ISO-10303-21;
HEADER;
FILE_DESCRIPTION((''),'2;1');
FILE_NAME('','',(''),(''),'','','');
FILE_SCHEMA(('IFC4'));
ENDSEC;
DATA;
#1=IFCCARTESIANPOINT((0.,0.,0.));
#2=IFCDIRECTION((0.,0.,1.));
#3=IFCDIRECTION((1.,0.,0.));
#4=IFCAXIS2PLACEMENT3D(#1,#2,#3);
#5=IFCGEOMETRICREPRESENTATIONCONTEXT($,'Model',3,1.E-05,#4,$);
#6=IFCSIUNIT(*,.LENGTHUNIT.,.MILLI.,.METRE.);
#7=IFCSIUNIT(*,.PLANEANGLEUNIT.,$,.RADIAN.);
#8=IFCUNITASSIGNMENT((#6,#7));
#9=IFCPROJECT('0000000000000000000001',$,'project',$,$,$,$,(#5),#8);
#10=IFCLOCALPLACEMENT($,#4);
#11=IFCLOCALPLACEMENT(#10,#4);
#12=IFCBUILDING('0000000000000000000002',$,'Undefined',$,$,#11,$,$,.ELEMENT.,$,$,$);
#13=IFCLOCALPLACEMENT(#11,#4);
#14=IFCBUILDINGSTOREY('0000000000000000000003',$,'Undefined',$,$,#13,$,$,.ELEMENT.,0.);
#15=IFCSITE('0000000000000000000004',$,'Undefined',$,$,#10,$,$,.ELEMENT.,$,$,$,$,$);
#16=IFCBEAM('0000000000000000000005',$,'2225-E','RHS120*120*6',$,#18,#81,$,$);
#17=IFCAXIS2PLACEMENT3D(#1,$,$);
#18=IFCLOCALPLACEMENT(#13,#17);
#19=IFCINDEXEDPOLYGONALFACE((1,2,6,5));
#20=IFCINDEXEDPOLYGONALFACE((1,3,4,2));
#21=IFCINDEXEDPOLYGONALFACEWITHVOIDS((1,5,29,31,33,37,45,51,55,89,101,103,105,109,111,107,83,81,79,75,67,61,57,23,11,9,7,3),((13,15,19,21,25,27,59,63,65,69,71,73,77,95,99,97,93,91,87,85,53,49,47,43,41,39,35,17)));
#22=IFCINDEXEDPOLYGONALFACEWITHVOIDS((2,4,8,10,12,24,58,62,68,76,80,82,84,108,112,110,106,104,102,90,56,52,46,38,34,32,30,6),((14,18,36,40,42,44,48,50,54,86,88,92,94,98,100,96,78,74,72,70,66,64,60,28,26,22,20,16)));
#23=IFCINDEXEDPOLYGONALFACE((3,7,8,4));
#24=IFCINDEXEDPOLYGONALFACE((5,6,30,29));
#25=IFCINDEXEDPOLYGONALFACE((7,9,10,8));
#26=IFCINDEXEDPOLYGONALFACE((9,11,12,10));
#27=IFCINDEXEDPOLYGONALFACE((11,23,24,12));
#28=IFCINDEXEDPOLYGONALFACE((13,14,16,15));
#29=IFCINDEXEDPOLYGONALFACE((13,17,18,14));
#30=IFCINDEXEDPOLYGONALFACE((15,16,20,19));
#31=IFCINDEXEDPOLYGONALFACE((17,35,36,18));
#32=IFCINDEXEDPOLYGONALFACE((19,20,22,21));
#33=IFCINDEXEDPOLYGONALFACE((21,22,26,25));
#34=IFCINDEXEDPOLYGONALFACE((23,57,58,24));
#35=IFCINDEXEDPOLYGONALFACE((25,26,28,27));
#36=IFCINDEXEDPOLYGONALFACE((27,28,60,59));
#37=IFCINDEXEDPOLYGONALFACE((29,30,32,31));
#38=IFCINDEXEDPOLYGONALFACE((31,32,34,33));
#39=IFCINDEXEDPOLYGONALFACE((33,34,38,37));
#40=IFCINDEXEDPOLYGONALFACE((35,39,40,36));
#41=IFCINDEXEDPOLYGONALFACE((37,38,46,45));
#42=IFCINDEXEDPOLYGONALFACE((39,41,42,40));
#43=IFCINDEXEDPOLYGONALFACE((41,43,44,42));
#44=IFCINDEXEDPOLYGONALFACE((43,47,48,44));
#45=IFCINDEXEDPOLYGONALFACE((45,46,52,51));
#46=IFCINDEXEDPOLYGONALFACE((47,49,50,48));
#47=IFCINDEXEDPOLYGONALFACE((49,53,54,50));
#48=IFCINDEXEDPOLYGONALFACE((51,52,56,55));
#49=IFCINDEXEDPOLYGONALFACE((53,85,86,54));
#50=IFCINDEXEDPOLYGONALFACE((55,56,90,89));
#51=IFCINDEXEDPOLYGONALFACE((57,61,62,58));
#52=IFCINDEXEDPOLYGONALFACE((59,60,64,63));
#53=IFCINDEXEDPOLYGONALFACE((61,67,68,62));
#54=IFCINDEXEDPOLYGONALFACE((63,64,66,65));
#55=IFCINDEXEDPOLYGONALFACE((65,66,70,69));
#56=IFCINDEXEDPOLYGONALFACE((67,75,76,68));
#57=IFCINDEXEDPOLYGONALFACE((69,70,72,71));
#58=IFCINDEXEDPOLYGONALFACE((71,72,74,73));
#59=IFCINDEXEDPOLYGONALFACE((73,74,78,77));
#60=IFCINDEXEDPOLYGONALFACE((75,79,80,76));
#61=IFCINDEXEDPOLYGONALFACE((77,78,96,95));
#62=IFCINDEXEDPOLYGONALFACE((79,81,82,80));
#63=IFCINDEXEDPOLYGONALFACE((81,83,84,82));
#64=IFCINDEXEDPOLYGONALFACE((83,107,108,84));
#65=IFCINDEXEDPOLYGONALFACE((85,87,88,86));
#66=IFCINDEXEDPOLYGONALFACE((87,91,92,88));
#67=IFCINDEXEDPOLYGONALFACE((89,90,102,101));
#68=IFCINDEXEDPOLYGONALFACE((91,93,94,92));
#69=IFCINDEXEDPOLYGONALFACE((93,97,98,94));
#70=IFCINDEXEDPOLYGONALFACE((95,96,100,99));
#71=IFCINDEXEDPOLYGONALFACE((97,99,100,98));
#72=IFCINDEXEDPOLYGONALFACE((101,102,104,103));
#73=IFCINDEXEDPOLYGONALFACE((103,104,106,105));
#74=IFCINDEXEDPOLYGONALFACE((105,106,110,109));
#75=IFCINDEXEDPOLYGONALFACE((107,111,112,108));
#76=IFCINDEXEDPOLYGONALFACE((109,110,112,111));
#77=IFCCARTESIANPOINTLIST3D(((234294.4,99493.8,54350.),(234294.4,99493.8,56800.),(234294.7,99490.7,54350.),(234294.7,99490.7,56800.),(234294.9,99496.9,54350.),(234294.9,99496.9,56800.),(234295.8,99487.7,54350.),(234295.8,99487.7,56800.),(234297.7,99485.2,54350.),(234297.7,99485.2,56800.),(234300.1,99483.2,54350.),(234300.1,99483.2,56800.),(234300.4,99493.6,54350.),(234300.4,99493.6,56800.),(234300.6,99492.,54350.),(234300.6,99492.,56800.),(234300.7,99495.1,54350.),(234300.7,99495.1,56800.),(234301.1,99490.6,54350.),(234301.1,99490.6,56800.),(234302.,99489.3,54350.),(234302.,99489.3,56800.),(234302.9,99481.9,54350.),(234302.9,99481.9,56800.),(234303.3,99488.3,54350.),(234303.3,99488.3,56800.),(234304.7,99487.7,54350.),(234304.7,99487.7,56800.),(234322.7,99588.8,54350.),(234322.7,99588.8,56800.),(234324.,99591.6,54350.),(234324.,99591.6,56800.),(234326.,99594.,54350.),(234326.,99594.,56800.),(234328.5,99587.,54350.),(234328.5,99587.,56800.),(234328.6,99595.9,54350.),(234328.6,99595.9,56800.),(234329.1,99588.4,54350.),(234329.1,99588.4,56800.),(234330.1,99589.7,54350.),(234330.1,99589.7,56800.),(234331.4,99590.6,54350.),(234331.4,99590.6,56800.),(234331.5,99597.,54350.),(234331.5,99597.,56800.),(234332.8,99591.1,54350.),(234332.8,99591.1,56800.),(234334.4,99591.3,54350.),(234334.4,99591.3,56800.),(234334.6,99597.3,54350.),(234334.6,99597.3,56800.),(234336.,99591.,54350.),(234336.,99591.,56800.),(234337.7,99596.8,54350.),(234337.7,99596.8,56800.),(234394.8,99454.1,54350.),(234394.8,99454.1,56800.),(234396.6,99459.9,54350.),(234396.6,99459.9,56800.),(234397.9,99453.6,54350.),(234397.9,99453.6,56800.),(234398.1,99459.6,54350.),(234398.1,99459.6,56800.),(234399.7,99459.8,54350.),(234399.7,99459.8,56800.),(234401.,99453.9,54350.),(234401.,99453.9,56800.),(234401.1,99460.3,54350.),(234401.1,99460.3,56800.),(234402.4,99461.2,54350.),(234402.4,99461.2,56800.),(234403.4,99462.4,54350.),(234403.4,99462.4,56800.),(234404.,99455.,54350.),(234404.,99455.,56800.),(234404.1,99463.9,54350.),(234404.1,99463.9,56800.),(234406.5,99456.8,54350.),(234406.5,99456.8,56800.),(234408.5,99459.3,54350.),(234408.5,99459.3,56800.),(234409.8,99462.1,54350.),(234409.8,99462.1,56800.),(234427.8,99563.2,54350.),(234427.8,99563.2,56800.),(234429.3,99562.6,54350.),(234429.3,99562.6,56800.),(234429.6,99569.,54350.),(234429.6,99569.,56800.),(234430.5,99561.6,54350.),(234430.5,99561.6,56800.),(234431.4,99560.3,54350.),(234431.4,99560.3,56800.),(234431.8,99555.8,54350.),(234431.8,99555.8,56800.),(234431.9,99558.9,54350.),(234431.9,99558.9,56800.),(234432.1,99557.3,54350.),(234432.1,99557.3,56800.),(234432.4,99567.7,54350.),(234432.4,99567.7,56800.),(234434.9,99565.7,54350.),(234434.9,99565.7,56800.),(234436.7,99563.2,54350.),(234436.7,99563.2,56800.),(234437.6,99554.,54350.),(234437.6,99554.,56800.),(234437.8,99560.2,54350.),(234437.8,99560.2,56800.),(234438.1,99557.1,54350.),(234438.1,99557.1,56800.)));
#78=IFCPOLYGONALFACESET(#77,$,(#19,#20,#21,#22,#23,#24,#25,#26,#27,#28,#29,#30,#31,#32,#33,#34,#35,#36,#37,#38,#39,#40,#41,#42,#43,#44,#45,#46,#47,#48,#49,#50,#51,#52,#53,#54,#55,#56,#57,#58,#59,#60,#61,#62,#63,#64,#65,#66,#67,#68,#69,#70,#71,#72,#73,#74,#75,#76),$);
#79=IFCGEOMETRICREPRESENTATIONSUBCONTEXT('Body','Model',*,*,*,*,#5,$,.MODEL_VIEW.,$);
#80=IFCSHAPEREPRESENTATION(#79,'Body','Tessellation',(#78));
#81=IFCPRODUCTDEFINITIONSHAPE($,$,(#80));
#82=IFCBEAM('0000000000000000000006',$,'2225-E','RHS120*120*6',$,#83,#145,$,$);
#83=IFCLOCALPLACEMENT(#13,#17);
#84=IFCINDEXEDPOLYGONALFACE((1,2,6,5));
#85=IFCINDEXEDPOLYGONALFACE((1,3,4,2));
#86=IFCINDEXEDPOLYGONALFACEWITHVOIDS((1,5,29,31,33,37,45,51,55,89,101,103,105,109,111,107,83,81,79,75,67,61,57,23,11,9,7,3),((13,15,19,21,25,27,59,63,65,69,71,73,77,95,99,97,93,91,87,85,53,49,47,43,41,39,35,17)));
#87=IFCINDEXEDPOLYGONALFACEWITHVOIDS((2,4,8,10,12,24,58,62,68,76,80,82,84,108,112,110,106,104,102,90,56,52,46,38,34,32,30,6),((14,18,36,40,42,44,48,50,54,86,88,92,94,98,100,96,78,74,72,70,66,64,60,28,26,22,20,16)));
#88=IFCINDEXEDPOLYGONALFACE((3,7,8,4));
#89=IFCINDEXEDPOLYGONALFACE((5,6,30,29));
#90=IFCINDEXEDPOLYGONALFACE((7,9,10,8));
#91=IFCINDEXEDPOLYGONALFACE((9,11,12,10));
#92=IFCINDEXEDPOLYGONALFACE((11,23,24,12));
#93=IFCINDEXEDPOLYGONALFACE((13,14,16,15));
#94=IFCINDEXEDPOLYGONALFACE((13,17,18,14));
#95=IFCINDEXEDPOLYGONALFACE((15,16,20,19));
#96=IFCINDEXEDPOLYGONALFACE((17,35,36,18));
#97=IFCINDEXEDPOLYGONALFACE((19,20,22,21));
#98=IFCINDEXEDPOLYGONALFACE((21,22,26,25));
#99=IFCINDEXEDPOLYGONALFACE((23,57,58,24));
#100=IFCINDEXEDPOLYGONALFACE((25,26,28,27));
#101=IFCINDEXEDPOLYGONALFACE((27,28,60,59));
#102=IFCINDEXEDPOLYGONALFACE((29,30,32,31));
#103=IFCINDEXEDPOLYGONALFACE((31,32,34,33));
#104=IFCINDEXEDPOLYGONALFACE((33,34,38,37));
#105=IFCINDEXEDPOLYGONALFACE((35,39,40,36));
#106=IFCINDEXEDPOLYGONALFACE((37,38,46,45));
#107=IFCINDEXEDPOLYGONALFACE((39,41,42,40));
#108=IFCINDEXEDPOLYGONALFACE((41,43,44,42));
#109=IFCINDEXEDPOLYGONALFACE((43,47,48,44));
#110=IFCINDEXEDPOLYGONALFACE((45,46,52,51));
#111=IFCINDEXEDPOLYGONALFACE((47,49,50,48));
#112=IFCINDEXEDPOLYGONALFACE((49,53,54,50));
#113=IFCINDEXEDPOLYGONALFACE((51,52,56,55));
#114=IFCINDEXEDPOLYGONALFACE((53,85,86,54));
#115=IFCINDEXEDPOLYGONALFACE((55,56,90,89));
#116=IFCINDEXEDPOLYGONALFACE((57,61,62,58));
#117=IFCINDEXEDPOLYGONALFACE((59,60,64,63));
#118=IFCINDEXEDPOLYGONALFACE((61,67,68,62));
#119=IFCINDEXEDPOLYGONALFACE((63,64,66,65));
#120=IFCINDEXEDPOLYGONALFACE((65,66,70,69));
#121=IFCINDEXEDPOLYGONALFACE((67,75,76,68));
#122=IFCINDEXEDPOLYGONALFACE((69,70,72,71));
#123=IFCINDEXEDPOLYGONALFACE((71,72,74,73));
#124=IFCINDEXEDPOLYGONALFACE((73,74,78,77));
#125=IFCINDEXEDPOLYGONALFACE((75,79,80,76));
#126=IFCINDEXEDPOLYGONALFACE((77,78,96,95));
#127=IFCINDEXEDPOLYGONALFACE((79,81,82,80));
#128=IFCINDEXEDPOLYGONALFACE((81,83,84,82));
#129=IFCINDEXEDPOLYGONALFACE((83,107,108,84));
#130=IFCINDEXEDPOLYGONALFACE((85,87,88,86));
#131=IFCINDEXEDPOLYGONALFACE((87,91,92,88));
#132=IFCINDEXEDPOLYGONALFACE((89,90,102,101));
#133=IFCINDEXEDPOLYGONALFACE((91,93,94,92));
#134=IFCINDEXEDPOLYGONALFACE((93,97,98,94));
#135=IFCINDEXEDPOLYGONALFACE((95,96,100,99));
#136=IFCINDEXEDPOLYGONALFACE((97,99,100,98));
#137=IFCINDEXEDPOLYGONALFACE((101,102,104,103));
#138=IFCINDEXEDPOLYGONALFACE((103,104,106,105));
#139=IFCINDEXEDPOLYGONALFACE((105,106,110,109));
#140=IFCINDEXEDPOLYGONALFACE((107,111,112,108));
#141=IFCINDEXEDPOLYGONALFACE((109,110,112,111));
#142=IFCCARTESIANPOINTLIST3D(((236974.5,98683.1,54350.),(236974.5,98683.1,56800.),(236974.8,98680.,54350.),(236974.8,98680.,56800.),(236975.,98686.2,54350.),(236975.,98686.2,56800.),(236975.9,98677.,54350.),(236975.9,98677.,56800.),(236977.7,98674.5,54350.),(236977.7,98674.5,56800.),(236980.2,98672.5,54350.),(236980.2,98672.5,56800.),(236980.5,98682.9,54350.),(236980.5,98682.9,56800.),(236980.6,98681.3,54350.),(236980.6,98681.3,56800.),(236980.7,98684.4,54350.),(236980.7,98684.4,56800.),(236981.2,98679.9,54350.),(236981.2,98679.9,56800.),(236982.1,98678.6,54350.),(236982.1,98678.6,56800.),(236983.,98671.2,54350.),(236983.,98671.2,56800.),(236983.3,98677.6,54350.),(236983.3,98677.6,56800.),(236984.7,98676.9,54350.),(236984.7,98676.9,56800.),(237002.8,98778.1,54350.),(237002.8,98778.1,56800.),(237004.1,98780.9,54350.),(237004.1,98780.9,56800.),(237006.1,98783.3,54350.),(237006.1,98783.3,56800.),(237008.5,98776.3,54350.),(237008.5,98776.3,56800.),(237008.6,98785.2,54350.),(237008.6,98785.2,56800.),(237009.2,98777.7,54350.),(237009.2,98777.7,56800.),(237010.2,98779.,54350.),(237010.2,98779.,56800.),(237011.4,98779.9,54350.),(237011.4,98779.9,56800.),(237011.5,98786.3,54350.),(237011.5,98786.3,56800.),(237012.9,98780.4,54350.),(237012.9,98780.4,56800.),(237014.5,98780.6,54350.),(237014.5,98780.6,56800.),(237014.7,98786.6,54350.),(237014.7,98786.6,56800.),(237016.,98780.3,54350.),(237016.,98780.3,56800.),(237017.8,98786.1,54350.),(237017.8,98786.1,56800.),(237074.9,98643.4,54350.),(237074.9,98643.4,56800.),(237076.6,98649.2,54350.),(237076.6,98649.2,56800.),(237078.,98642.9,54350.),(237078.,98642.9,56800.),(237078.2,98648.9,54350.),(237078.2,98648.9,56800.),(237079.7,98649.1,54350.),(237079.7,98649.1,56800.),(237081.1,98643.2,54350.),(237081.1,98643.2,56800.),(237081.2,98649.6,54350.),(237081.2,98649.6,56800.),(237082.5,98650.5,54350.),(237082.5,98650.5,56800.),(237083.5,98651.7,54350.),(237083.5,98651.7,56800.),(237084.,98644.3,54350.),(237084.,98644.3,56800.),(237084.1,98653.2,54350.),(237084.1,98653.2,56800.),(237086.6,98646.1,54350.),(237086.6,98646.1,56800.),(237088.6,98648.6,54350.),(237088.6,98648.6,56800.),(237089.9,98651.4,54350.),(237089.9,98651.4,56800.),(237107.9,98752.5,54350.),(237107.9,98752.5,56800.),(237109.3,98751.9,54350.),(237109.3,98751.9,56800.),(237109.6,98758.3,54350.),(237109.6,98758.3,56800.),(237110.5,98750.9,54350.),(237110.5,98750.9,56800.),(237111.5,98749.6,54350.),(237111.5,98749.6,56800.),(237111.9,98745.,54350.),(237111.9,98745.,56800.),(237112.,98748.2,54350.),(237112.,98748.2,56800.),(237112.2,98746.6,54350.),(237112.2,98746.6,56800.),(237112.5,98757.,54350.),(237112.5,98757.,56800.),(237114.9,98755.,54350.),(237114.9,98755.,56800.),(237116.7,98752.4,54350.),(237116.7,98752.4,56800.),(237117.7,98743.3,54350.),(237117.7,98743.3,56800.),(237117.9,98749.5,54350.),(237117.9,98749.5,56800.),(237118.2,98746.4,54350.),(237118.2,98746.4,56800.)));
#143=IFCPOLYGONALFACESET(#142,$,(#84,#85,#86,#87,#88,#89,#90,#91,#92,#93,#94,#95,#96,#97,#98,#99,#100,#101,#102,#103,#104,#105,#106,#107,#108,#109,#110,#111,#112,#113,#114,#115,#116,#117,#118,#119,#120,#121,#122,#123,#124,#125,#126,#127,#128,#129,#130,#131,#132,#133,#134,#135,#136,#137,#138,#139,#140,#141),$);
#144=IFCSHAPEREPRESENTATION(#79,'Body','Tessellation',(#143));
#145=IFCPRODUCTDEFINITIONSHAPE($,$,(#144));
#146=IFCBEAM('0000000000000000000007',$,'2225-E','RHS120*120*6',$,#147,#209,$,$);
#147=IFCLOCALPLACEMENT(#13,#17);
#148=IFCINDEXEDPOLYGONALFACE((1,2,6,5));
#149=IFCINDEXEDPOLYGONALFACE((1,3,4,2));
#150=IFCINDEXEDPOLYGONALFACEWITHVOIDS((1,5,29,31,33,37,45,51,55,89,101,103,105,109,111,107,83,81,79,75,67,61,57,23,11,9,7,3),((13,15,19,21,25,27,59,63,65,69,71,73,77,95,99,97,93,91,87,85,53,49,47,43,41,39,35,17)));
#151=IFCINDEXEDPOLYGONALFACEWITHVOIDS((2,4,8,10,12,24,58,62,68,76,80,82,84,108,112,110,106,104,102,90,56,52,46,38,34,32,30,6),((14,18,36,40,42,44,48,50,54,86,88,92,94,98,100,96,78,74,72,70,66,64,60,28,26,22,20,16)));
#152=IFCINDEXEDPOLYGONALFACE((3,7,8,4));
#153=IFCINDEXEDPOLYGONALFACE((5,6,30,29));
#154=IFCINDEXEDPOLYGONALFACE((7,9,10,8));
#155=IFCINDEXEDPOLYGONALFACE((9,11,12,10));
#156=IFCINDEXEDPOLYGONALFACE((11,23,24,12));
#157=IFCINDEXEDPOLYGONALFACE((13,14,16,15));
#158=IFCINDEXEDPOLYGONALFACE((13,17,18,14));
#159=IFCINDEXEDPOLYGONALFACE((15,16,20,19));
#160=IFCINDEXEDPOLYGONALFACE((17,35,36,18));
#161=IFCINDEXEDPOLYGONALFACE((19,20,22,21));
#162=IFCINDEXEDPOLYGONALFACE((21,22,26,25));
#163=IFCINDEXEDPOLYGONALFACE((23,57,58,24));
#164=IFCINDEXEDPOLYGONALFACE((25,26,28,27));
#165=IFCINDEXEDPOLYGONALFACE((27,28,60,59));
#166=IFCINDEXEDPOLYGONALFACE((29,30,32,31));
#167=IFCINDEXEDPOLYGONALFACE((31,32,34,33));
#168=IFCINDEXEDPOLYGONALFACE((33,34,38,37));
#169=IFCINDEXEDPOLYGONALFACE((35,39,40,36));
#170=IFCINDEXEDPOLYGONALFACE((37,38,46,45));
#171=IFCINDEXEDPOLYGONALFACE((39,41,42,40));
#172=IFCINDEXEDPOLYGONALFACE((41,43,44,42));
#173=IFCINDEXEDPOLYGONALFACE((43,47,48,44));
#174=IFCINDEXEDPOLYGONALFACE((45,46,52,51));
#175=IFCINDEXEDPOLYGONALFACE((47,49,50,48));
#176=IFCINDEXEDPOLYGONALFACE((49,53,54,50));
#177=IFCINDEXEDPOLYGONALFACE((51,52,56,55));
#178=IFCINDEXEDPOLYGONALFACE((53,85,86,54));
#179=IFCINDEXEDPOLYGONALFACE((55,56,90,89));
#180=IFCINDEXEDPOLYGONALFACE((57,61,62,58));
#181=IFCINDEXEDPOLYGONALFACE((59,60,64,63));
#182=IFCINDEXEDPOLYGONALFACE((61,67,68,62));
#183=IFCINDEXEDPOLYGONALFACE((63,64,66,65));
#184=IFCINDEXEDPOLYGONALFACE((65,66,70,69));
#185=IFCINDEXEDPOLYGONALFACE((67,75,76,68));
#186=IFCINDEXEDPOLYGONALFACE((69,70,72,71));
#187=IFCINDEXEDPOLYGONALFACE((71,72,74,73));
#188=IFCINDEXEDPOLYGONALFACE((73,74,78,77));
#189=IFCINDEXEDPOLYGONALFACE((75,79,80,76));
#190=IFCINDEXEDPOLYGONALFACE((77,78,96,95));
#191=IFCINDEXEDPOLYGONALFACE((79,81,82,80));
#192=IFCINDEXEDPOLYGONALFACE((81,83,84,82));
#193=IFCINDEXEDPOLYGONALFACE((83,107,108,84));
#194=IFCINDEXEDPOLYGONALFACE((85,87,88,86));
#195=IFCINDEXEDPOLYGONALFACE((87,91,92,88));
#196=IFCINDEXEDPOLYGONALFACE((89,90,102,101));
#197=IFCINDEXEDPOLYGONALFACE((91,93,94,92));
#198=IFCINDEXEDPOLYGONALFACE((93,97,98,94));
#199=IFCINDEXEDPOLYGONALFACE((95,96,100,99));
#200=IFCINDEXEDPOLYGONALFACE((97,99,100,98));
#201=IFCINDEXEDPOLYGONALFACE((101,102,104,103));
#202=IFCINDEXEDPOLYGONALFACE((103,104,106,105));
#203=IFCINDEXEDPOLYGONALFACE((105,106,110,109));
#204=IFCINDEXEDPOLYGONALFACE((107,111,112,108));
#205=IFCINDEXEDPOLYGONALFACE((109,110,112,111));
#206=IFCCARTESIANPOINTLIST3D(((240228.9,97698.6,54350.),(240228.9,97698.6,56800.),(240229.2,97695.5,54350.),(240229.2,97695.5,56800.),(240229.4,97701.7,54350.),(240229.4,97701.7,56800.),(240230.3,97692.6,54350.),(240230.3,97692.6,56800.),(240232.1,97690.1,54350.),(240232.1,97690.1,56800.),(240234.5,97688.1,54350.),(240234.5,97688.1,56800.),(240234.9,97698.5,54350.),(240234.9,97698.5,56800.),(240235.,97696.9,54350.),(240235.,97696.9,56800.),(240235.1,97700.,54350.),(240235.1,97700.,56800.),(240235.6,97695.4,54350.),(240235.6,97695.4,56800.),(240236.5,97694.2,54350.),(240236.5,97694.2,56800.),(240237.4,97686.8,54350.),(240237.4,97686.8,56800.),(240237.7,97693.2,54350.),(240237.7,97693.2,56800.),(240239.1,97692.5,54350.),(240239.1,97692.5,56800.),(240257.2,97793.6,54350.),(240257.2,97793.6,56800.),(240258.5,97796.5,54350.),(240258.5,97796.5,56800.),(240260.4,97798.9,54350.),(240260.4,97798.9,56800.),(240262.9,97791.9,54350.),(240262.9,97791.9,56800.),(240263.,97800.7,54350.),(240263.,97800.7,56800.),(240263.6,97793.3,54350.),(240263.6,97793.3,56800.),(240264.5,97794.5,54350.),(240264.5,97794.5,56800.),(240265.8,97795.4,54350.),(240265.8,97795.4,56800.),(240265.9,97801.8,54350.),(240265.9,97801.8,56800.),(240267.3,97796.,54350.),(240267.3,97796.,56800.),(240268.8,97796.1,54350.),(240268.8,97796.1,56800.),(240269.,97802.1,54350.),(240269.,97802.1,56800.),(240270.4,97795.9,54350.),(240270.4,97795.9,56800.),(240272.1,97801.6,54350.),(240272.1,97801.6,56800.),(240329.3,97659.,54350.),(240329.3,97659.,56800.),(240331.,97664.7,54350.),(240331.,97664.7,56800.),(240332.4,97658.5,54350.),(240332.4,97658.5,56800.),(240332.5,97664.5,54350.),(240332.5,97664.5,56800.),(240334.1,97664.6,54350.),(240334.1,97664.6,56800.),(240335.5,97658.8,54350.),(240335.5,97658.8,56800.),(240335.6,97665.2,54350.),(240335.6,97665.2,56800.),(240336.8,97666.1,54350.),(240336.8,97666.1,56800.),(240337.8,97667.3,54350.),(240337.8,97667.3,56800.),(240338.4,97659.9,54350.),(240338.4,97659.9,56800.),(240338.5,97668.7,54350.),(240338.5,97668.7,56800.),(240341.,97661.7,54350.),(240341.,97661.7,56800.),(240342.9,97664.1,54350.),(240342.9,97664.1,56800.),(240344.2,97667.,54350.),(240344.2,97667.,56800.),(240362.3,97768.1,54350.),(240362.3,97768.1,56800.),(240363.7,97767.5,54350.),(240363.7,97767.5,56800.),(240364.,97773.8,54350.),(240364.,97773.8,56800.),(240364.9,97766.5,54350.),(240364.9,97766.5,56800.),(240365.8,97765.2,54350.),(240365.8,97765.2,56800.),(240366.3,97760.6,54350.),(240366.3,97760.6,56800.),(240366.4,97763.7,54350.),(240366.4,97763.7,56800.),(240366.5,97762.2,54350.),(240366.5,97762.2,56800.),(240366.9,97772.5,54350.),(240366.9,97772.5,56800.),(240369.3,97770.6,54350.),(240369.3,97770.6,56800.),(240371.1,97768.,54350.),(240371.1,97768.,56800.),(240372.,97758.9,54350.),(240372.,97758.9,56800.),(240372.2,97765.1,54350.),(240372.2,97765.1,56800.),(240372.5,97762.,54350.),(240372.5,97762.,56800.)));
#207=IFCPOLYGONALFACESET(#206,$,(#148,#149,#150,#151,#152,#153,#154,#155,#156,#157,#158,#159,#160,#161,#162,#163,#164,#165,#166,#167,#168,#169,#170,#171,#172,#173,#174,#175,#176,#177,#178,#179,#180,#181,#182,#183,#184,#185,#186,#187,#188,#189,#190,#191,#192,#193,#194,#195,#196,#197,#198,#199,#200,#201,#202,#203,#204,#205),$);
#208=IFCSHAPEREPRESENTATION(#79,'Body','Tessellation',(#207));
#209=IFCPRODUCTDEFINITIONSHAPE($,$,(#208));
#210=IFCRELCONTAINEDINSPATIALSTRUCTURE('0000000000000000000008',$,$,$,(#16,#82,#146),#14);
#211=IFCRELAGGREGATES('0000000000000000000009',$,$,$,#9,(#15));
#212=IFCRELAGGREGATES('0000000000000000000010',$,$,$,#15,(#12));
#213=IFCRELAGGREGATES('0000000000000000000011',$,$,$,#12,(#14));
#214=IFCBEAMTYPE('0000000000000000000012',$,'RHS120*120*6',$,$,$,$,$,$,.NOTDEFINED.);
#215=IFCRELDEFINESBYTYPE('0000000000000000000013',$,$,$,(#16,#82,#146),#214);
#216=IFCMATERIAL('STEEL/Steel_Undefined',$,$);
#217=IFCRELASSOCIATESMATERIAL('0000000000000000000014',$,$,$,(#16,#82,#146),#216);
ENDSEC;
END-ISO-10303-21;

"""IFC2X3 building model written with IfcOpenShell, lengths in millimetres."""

from ifc_helpers import new_model, si_unit, frame, origin_with_axes, origin_2d_with_axis, place, context, subcontext, project, spatial, hollow_rectangle, extrude, material, type_object, element, save


model = new_model("IFC2X3")

# Units and contexts
model_context = context("Model", 3, precision=1e-05, world=origin_with_axes())
body_context = subcontext(model_context, "Body", "Model", "MODEL_VIEW")
ifc_project = project(units=[si_unit("LENGTHUNIT", "METRE", prefix="MILLI"), si_unit("PLANEANGLEUNIT", "RADIAN")], contexts=[model_context])

# Site, building, storey
site_placement = place(None, origin_with_axes())
site = spatial("IfcSite", under=ifc_project, at=site_placement, Name="Undefined", CompositionType="ELEMENT")
building_placement = place(site_placement, origin_with_axes())
building = spatial("IfcBuilding", under=site, at=building_placement, Name="Undefined", CompositionType="ELEMENT")
storey_placement = place(building_placement, origin_with_axes())
storey = spatial("IfcBuildingStorey", under=building, at=storey_placement, Name="Undefined", CompositionType="ELEMENT", Elevation=0.0)

# Shared definitions
ifc_material_1 = material(Name="STEEL/Steel_Undefined")

# Beams
beam_type_1 = type_object("IfcBeamType", Name="RHS120*120*6", PredefinedType="NOTDEFINED")
for number, where, z_axis, x_axis, name in (
    (1, (234366.3, 99525.4, 54350.0), (-0.957167, 0.289538, 0.0), (0.0, 0.0, 1.0), "2225-E"),
    (2, (237046.3, 98714.7, 54350.0), (-0.957167, 0.289538, 0.0), (0.0, 0.0, 1.0), "2225-E"),
    (3, (240300.7, 97730.3, 54350.0), (-0.957167, 0.289538, 0.0), (0.0, 0.0, 1.0), "2225-E"),
):
    element("IfcBeam", number, at=place(storey_placement, frame(where, z_axis=z_axis, x_axis=x_axis)), inside=storey, type_object=beam_type_1, material=ifc_material_1, Name=name, Description="RHS120*120*6", context=body_context, shape_type="SweptSolid", body=[
        extrude(hollow_rectangle(XDim=120.0, YDim=120.0, WallThickness=6.0, InnerFilletRadius=6.0, OuterFilletRadius=12.0, at=origin_2d_with_axis()), frame((2450.0, 0.0, 0.0), z_axis=(-1.0, 0.0, 0.0), x_axis=(0.0, -1.0, 0.0)), (0.0, 0.0, 1.0), 2450.0),
    ])

save(model, "model.ifc")
